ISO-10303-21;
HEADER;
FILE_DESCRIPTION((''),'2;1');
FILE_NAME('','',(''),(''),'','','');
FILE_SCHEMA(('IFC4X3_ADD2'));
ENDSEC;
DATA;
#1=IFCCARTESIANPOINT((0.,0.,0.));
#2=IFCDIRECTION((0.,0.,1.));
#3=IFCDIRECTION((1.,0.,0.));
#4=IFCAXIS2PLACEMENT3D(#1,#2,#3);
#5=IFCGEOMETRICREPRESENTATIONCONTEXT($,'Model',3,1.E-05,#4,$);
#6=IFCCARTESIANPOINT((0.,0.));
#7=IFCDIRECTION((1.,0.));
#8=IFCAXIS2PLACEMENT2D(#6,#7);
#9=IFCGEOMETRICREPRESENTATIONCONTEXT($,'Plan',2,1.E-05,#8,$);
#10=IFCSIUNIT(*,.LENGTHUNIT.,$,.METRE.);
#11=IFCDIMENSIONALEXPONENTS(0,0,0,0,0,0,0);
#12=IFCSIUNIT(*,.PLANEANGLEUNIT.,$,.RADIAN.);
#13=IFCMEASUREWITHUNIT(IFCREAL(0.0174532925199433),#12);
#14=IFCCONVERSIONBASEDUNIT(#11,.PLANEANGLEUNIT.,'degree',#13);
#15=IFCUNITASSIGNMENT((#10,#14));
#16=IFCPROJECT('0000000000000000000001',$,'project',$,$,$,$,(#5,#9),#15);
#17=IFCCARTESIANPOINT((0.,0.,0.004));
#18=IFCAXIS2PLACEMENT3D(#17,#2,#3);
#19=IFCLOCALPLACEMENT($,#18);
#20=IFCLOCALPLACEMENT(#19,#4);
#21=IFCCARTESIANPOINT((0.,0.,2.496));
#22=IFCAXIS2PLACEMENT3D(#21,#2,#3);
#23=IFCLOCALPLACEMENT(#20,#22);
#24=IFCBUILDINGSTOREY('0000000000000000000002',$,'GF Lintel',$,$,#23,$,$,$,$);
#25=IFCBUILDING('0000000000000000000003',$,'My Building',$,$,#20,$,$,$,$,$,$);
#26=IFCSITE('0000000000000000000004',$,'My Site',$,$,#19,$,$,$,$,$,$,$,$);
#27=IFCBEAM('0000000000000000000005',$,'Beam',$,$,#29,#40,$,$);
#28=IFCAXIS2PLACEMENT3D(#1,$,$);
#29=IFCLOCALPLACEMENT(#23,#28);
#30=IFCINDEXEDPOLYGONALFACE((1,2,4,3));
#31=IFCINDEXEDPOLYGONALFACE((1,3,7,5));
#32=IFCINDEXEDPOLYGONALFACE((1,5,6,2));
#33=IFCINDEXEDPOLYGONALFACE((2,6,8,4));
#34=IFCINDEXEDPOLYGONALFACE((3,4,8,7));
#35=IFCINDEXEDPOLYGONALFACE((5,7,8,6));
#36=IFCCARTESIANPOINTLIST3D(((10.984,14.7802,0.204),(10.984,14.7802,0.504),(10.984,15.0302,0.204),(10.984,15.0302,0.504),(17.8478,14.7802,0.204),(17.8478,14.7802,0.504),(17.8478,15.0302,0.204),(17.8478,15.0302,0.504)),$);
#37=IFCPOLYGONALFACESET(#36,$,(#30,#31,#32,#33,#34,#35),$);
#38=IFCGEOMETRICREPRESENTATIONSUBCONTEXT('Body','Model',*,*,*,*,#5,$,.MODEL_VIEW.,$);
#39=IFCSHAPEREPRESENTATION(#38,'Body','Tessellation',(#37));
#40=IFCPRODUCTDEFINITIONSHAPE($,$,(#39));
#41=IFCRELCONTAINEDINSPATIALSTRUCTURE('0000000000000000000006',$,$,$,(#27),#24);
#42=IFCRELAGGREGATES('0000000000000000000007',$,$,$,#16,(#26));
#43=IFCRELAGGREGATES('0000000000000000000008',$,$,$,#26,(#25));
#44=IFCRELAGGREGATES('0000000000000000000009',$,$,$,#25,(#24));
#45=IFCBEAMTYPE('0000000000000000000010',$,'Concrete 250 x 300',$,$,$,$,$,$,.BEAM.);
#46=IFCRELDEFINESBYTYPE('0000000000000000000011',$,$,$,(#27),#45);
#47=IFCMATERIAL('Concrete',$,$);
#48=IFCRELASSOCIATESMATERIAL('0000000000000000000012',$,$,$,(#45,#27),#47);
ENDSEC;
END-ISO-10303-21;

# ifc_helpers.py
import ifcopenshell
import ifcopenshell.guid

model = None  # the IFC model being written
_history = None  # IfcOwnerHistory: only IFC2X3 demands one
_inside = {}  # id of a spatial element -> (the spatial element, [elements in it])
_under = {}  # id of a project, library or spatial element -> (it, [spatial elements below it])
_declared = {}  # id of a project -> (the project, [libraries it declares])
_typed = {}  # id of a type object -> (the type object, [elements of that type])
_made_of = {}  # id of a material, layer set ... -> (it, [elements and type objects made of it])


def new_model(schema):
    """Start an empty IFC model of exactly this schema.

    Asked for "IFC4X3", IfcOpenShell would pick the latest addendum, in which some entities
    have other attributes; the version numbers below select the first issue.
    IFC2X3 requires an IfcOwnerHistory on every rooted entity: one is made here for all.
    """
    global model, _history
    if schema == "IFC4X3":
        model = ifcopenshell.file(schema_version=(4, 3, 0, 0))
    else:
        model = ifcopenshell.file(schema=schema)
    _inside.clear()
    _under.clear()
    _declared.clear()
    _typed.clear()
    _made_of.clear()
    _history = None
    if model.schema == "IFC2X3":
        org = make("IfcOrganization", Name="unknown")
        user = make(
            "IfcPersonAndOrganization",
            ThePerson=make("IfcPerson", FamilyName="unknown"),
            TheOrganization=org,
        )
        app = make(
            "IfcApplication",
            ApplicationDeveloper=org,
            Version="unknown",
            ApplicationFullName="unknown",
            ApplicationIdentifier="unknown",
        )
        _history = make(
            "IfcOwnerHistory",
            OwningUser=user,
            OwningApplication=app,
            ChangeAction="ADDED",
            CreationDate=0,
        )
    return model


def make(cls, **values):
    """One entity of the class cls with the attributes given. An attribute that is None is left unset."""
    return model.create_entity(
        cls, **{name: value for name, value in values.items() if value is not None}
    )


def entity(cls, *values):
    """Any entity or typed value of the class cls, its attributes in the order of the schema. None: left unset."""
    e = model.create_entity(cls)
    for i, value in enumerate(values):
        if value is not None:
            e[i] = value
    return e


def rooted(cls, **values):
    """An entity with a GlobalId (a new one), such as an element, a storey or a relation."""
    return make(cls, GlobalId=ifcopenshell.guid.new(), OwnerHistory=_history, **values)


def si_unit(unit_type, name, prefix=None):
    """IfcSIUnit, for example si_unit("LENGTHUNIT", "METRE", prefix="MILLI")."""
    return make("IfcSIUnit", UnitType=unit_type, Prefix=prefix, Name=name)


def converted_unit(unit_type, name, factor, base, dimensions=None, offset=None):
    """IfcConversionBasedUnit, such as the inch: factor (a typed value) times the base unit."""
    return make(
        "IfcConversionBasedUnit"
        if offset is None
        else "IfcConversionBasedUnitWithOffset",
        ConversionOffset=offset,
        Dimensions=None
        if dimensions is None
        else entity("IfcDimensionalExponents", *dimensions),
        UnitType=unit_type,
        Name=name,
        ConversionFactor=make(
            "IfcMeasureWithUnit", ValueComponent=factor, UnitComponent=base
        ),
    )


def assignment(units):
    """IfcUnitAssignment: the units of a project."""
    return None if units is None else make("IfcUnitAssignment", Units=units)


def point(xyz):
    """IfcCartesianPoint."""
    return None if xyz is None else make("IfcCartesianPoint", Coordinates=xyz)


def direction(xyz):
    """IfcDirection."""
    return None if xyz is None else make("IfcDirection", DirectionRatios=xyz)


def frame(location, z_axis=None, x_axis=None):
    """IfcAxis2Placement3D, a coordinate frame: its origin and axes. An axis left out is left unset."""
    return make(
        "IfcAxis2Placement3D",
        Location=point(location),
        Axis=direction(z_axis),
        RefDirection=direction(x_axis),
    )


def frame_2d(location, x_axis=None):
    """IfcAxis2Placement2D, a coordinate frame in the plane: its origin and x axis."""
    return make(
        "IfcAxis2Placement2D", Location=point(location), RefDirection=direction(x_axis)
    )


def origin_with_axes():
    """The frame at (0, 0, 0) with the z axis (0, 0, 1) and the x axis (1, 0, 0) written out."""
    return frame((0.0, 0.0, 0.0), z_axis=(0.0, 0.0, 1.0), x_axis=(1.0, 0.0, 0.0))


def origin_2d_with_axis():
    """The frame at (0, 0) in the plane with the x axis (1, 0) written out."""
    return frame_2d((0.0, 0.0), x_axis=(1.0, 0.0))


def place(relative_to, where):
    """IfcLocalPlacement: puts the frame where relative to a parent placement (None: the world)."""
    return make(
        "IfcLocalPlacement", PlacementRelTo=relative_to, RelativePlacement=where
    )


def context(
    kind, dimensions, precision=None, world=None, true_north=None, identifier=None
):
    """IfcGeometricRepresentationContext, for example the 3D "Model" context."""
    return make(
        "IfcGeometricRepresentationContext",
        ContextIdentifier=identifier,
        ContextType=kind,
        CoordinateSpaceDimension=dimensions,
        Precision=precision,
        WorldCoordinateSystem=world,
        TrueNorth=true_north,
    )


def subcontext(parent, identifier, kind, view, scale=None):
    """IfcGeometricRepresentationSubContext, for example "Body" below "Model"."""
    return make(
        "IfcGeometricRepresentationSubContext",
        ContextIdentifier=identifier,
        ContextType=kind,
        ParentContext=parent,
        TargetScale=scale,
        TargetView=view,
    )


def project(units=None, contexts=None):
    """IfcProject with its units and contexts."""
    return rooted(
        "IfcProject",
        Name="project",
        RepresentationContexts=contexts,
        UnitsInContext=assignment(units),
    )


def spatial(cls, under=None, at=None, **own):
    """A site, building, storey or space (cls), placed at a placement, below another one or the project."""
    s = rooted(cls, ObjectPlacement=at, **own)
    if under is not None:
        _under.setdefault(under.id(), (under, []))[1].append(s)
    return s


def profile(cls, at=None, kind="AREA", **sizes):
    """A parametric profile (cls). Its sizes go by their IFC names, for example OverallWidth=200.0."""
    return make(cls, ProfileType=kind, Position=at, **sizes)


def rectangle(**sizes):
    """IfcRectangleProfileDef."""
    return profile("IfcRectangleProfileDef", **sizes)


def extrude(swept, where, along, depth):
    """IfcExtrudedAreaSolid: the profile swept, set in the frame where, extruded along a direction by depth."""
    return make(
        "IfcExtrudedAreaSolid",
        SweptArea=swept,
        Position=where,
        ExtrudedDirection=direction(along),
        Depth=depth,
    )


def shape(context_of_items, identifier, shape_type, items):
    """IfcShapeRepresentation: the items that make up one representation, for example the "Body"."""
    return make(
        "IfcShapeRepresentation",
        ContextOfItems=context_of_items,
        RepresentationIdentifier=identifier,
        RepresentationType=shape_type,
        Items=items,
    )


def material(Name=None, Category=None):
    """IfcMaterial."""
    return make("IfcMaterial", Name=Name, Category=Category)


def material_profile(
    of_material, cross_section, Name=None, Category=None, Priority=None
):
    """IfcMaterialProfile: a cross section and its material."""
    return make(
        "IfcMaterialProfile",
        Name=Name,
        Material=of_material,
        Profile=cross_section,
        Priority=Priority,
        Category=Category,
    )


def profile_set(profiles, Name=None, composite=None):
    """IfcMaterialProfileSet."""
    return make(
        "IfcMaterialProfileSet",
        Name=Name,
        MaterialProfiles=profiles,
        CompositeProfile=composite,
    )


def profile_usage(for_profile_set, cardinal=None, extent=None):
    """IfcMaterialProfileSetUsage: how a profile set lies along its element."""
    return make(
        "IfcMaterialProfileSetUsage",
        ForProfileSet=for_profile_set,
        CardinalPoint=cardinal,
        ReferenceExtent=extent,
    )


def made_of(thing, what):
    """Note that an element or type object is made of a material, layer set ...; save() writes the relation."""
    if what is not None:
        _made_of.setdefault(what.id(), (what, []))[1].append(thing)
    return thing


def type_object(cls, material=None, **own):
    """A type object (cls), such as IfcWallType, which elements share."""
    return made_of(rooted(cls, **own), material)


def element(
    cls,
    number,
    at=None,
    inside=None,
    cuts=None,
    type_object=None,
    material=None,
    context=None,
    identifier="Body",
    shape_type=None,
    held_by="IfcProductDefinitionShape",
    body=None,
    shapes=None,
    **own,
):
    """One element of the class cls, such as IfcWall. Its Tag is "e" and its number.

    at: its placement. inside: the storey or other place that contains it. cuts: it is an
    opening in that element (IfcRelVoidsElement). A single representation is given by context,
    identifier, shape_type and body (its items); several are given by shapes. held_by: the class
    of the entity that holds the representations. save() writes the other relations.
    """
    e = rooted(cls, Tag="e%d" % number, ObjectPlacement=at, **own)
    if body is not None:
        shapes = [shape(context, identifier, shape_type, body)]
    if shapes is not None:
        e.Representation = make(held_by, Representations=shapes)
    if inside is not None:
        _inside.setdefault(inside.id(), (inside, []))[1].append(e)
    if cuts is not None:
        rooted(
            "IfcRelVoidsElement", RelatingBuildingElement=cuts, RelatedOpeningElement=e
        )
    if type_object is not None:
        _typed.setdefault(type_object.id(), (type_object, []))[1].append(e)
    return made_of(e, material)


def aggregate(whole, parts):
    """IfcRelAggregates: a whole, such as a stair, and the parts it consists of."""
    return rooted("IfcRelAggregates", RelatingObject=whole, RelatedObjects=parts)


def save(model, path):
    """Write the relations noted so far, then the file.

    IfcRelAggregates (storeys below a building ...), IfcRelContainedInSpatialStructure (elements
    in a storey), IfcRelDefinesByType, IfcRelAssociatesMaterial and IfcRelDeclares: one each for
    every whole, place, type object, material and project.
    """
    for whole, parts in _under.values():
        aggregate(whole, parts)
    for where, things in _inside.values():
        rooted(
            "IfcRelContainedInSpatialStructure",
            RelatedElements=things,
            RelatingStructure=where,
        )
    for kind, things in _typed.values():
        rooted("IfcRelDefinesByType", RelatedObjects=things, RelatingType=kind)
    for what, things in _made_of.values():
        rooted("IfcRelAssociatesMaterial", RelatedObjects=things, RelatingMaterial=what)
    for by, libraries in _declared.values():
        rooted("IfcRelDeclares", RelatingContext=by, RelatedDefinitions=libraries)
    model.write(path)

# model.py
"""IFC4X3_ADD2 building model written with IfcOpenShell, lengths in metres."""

from ifc_helpers import new_model, entity, si_unit, converted_unit, frame, origin_with_axes, origin_2d_with_axis, place, context, subcontext, project, spatial, rectangle, extrude, material, material_profile, profile_set, profile_usage, type_object, element, save


model = new_model("IFC4X3_ADD2")

# Units and contexts
model_context = context("Model", 3, precision=1e-05, world=origin_with_axes())
plan_context = context("Plan", 2, precision=1e-05, world=origin_2d_with_axis())
body_context = subcontext(model_context, "Body", "Model", "MODEL_VIEW")
ifc_project = project(units=[si_unit("LENGTHUNIT", "METRE"), converted_unit("PLANEANGLEUNIT", "degree", entity("IfcReal", 0.0174532925199433), si_unit("PLANEANGLEUNIT", "RADIAN"), dimensions=[0, 0, 0, 0, 0, 0, 0])], contexts=[model_context, plan_context])

# Site, building, storey
site_placement = place(None, frame((0.0, 0.0, 0.004), z_axis=(0.0, 0.0, 1.0), x_axis=(1.0, 0.0, 0.0)))
site = spatial("IfcSite", under=ifc_project, at=site_placement, Name="My Site")
building_placement = place(site_placement, origin_with_axes())
building = spatial("IfcBuilding", under=site, at=building_placement, Name="My Building")
storey_placement = place(building_placement, frame((0.0, 0.0, 2.496), z_axis=(0.0, 0.0, 1.0), x_axis=(1.0, 0.0, 0.0)))
storey = spatial("IfcBuildingStorey", under=building, at=storey_placement, Name="GF Lintel")

# Beam
ifc_material = material(Name="Concrete")
ifc_material_profile = material_profile(ifc_material, rectangle(XDim=0.25, YDim=0.3))
ifc_profile_set = profile_set([ifc_material_profile])
ifc_profile_usage = profile_usage(ifc_profile_set, cardinal=5)
beam_type = type_object("IfcBeamType", Name="Concrete 250 x 300", PredefinedType="BEAM", material=ifc_profile_set)
beam_placement = place(storey_placement, frame((10.984, 14.9052, 0.354), z_axis=(1.0, 0.0, 0.0), x_axis=(0.0, 1.0, 0.0)))
element("IfcBeam", 1, at=beam_placement, inside=storey, type_object=beam_type, material=ifc_profile_usage, Name="Beam", context=body_context, shape_type="SweptSolid", body=[
    extrude(rectangle(XDim=0.25, YDim=0.3), origin_with_axes(), (0.0, 0.0, 1.0), 6.8638),
])

save(model, "model.ifc")
